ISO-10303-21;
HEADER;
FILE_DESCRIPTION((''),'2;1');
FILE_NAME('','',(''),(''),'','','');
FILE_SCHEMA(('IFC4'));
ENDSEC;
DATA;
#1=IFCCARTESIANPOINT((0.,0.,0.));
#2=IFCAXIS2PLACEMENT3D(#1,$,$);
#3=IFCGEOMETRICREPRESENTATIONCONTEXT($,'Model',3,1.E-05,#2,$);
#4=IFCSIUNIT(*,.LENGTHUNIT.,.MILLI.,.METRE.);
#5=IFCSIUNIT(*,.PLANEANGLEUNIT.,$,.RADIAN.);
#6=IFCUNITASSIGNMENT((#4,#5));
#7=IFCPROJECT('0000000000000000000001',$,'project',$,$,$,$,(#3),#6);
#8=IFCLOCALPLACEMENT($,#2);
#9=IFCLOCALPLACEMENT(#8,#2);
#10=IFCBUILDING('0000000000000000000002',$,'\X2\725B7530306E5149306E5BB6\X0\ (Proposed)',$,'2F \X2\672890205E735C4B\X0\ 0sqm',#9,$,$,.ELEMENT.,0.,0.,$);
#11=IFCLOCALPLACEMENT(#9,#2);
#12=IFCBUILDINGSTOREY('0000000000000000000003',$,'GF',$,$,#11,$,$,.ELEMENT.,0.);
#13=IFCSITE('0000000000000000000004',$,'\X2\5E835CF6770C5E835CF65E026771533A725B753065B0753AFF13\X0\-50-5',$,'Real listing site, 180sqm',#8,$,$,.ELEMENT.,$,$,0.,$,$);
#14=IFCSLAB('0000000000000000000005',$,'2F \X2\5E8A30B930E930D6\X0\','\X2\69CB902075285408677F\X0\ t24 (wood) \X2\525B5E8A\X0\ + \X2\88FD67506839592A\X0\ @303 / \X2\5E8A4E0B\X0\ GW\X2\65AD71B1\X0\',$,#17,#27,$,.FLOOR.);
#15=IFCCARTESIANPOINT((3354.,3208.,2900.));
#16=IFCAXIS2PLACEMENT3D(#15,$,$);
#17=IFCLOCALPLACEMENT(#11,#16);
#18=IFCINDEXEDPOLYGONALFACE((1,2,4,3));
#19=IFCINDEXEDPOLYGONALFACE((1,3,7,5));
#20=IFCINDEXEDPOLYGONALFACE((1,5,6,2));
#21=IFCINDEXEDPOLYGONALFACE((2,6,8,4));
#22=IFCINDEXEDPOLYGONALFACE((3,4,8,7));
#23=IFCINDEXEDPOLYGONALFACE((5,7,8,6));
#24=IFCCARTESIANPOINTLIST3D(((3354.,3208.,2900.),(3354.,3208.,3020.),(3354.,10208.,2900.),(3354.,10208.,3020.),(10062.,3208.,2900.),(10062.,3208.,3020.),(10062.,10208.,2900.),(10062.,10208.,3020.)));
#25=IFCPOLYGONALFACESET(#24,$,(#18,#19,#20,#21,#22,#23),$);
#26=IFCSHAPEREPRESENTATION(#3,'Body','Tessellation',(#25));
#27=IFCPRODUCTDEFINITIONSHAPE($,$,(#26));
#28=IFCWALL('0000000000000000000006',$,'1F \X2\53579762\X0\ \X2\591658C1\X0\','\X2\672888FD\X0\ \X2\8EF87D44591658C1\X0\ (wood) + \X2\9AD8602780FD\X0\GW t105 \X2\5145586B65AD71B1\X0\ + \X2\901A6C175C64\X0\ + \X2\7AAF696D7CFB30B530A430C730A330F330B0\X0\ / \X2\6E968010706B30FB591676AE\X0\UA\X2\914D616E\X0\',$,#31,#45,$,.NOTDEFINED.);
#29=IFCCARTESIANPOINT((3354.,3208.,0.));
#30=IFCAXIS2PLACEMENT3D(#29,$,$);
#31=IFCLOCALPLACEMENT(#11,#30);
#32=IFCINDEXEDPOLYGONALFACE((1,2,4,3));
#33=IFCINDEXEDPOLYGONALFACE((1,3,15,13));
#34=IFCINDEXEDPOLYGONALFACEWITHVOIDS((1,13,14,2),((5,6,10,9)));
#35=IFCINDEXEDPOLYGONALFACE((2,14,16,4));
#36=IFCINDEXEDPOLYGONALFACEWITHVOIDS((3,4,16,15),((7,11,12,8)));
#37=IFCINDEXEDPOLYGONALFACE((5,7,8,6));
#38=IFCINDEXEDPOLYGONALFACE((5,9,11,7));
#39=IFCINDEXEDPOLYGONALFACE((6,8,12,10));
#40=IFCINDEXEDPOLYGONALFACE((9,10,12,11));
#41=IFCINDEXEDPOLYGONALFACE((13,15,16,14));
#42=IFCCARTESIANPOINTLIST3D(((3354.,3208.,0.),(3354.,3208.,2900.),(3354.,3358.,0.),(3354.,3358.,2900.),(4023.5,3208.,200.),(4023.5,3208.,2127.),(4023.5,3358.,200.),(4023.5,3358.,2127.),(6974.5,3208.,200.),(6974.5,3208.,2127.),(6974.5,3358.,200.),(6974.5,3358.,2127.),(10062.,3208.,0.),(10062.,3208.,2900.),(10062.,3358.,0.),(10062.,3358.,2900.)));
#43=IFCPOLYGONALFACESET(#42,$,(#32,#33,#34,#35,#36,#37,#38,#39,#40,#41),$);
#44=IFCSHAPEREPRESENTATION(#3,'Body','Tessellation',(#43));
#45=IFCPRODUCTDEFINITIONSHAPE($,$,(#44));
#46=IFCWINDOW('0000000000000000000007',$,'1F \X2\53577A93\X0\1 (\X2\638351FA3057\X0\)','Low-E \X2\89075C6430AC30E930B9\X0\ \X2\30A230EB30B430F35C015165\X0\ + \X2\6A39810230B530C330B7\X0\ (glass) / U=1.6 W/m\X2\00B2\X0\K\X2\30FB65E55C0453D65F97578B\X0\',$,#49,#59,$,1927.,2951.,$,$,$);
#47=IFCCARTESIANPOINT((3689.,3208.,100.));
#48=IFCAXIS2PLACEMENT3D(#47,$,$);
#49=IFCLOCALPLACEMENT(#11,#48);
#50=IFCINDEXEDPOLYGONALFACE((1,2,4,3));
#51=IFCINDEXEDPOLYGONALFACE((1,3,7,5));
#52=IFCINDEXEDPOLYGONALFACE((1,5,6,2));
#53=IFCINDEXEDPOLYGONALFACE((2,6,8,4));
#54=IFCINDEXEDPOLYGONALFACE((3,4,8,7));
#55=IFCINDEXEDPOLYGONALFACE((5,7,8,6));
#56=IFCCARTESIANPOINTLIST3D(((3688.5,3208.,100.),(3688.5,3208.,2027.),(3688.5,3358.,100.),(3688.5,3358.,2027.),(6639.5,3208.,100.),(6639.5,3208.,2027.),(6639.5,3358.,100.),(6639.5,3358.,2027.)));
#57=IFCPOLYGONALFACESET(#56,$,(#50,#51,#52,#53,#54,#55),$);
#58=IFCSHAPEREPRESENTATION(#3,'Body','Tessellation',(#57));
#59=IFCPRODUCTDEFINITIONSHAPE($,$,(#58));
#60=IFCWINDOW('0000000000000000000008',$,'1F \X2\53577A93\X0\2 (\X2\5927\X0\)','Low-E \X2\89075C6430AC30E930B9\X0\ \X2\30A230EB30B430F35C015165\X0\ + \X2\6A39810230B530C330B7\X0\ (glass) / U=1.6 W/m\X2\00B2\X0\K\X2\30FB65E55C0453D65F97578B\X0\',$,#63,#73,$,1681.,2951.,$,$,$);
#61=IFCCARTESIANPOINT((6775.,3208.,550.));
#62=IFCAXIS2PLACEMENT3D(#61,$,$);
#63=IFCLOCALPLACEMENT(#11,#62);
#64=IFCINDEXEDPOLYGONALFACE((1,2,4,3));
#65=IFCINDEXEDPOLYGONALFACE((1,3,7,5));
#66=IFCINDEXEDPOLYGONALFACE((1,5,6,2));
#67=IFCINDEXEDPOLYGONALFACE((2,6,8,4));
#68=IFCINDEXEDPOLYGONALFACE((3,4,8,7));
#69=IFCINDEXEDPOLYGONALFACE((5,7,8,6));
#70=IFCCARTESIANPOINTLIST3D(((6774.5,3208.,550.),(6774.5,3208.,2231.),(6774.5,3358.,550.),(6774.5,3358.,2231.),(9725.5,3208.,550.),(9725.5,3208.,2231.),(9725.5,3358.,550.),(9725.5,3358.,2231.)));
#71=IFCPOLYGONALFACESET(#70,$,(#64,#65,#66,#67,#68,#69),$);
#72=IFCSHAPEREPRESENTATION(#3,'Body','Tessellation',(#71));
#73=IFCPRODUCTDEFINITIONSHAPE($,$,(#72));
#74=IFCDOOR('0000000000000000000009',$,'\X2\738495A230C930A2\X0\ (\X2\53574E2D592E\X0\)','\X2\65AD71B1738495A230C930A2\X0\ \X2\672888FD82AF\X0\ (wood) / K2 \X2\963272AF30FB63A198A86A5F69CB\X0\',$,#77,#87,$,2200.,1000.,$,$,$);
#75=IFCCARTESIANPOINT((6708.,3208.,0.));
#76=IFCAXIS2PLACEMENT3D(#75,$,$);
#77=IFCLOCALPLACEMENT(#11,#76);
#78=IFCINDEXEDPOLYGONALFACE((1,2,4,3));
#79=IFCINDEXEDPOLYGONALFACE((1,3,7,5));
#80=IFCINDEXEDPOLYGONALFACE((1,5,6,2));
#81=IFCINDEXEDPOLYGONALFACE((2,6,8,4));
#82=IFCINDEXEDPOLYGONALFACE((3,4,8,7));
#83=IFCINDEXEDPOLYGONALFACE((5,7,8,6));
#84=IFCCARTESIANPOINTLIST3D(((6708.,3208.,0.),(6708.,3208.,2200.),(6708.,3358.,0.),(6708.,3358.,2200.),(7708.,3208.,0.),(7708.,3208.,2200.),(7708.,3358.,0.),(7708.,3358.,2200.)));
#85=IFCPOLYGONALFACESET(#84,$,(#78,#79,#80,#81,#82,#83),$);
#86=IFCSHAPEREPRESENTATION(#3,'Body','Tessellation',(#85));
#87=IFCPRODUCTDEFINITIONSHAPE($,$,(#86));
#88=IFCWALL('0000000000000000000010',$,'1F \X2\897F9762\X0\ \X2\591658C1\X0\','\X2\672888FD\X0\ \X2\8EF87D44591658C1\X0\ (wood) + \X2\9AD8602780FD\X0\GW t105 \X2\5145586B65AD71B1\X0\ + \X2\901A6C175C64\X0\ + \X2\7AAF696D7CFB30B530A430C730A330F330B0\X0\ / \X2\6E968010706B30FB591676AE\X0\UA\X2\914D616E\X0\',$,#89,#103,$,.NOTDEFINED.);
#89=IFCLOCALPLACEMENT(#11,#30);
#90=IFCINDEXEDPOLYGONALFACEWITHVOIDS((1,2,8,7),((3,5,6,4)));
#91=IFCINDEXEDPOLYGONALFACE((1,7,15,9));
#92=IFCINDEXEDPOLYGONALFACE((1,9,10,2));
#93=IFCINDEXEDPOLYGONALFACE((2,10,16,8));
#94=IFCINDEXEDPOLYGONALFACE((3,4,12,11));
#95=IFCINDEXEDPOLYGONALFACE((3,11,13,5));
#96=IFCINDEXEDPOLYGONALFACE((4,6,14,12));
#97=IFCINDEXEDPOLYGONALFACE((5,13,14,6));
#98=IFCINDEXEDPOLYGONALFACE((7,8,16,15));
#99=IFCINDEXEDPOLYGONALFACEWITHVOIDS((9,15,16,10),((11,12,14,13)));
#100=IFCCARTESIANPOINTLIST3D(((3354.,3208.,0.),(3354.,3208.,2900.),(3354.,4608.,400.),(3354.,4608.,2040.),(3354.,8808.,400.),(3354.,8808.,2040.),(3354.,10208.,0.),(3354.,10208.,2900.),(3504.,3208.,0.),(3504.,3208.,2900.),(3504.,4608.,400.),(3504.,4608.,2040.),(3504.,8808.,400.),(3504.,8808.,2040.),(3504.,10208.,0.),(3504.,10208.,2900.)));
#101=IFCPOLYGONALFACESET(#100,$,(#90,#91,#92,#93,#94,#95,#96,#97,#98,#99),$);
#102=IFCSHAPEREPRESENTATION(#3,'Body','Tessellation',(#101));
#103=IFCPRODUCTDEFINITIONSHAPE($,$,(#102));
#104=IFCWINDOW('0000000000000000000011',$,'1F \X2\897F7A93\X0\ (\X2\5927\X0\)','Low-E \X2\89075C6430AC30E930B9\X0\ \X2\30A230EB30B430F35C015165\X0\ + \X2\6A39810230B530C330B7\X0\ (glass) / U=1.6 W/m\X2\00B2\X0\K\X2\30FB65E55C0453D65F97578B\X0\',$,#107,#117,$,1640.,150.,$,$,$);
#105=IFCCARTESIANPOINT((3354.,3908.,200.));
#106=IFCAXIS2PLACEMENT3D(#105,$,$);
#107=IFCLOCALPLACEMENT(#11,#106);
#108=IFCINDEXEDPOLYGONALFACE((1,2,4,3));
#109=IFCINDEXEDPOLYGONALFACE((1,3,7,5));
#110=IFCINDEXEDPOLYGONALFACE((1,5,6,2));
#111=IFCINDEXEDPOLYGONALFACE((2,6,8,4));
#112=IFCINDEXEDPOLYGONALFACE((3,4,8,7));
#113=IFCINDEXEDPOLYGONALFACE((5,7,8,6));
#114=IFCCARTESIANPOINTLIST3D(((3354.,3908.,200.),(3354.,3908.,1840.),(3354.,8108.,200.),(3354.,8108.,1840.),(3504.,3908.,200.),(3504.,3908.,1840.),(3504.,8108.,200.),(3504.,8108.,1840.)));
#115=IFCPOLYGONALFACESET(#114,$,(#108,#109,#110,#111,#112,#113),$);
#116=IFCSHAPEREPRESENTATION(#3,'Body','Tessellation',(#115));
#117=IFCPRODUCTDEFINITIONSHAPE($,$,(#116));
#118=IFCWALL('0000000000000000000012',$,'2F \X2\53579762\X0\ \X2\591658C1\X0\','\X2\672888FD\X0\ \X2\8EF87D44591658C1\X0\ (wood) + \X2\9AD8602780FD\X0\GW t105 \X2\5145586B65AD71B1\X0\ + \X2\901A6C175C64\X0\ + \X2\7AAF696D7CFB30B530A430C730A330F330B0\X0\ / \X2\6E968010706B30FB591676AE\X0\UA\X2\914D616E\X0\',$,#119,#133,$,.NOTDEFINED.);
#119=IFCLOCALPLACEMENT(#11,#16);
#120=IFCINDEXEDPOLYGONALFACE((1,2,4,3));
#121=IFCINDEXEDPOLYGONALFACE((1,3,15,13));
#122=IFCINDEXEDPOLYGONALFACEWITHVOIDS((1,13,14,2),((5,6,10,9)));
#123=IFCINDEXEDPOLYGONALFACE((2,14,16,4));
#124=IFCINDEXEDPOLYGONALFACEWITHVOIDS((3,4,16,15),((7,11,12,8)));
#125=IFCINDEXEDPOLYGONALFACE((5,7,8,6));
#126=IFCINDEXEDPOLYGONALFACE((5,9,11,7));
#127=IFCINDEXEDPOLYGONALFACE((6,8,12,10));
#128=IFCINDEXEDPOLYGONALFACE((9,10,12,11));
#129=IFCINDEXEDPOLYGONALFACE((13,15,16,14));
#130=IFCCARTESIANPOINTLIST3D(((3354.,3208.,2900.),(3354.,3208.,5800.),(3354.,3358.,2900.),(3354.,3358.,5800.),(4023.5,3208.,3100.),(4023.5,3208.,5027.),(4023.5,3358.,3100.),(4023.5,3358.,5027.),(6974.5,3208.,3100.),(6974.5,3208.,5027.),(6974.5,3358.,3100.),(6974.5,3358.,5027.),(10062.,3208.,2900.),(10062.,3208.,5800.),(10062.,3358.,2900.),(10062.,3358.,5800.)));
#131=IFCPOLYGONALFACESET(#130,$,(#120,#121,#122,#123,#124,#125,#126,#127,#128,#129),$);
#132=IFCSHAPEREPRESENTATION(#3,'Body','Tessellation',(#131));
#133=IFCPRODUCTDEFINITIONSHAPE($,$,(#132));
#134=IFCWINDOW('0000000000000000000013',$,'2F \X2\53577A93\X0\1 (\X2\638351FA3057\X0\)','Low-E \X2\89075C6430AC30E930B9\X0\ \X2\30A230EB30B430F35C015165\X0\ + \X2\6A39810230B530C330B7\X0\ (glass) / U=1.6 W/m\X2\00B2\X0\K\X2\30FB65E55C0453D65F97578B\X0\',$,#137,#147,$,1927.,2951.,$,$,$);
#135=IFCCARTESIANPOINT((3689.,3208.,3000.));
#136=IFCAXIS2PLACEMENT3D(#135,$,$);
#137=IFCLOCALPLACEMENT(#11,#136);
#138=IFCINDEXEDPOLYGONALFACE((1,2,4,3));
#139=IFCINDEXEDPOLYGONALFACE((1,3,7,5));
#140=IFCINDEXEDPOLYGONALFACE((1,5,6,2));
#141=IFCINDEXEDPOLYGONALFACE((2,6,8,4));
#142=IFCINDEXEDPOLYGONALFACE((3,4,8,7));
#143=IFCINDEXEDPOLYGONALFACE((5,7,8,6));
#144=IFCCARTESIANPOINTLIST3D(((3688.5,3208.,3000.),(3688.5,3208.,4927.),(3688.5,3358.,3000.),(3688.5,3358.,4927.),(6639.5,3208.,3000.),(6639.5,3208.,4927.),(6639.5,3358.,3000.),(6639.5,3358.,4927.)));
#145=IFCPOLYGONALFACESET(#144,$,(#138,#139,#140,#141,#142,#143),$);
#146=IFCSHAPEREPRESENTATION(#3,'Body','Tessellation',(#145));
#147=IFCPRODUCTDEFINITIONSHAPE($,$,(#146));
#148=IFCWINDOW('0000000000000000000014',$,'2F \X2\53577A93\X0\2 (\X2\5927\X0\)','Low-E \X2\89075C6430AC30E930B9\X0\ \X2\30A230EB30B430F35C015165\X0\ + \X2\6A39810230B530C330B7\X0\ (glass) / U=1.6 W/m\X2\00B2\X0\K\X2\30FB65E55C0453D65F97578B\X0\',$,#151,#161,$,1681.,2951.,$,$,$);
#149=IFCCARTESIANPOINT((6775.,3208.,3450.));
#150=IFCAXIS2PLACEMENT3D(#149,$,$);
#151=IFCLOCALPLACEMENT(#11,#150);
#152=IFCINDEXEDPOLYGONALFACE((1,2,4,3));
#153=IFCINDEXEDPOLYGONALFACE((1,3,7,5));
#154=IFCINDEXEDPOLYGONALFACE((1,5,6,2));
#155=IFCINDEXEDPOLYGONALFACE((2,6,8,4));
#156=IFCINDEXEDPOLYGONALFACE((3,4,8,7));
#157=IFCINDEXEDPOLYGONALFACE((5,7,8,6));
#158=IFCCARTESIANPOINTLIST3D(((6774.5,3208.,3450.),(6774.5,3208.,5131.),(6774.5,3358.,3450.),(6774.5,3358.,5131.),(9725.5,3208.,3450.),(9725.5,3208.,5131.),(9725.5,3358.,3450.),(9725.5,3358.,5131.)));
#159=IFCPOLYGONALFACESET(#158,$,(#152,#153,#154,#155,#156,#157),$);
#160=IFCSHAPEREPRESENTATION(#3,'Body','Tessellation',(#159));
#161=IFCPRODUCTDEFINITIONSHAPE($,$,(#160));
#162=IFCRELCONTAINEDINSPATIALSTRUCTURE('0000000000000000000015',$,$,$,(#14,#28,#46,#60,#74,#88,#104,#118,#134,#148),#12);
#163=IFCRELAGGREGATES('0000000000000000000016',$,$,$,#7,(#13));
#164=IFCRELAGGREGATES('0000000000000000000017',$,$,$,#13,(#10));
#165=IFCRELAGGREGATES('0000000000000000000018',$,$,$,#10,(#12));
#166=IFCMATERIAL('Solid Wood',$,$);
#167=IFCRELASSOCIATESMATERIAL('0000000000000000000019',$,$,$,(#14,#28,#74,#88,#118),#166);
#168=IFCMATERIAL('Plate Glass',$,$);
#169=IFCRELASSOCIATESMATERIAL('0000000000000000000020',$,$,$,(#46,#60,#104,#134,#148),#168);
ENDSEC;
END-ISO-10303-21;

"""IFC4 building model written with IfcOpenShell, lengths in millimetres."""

from ifc_helpers import new_model, si_unit, frame, frame_2d, origin, place, context, project, spatial, rectangle, extrude, material, element, fill, save


model = new_model("IFC4")

# Units and contexts
model_context = context("Model", 3, precision=1e-05, world=origin())
ifc_project = project(units=[si_unit("LENGTHUNIT", "METRE", prefix="MILLI"), si_unit("PLANEANGLEUNIT", "RADIAN")], contexts=[model_context])

# Site, building, storey
site_placement = place(None, origin())
site = spatial("IfcSite", under=ifc_project, at=site_placement, Name="広島県広島市東区牛田新町３-50-5", ObjectType="Real listing site, 180sqm", CompositionType="ELEMENT", RefElevation=0.0)
building_placement = place(site_placement, origin())
building = spatial("IfcBuilding", under=site, at=building_placement, Name="牛田の光の家 (Proposed)", ObjectType="2F 木造平屋 0sqm", CompositionType="ELEMENT", ElevationOfRefHeight=0.0, ElevationOfTerrain=0.0)
storey_placement = place(building_placement, origin())
storey = spatial("IfcBuildingStorey", under=building, at=storey_placement, Name="GF", CompositionType="ELEMENT", Elevation=0.0)

# Slab
ifc_material_1 = material(Name="Solid Wood")
slab_1_placement = place(storey_placement, frame((3354.0, 3208.0, 2900.0)))
element("IfcSlab", 1, at=slab_1_placement, inside=storey, material=ifc_material_1, Name="2F 床スラブ", Description="構造用合板 t24 (wood) 剛床 + 製材根太 @303 / 床下 GW断熱", PredefinedType="FLOOR", context=model_context, shape_type="SweptSolid", body=[
    extrude(rectangle(XDim=6708.0, YDim=7000.0, at=frame_2d((3354.0, 3500.0))), frame((3354.0, 3208.0, 2900.0)), (0.0, 0.0, 1.0), 120.0),
])

# Wall, openings, windows, door
wall_1_placement = place(storey_placement, frame((3354.0, 3208.0, 0.0)))
wall_1 = element("IfcWall", 2, at=wall_1_placement, inside=storey, material=ifc_material_1, Name="1F 南面 外壁", Description="木製 軸組外壁 (wood) + 高性能GW t105 充填断熱 + 通気層 + 窯業系サイディング / 準耐火・外皮UA配慮", PredefinedType="NOTDEFINED", context=model_context, shape_type="SweptSolid", body=[
    extrude(rectangle(XDim=6708.0, YDim=150.0, at=frame_2d((3354.0, 75.0))), frame((3354.0, 3208.0, 0.0)), (0.0, 0.0, 1.0), 2900.0),
])
opening_1_placement = place(storey_placement, frame((3689.0, 3208.0, 100.0)))
opening_1 = element("IfcOpeningElement", 3, at=opening_1_placement, cuts=wall_1, PredefinedType="NOTDEFINED", context=model_context, shape_type="SweptSolid", body=[
    extrude(rectangle(XDim=2951.0, YDim=150.0, at=frame_2d((1475.0, 75.0))), frame((3689.0, 3208.0, 100.0)), (0.0, 0.0, 1.0), 1927.0),
])
opening_2_placement = place(storey_placement, frame((6775.0, 3208.0, 550.0)))
opening_2 = element("IfcOpeningElement", 4, at=opening_2_placement, cuts=wall_1, PredefinedType="NOTDEFINED", context=model_context, shape_type="SweptSolid", body=[
    extrude(rectangle(XDim=2951.0, YDim=150.0, at=frame_2d((1475.0, 75.0))), frame((6775.0, 3208.0, 550.0)), (0.0, 0.0, 1.0), 1681.0),
])
opening_3_placement = place(storey_placement, frame((6708.0, 3208.0, 0.0)))
opening_3 = element("IfcOpeningElement", 5, at=opening_3_placement, cuts=wall_1, PredefinedType="NOTDEFINED", context=model_context, shape_type="SweptSolid", body=[
    extrude(rectangle(XDim=1000.0, YDim=150.0, at=frame_2d((500.0, 75.0))), frame((6708.0, 3208.0, 0.0)), (0.0, 0.0, 1.0), 2200.0),
])
ifc_material_2 = material(Name="Plate Glass")
window_1_placement = place(storey_placement, frame((3689.0, 3208.0, 100.0)))
window_1 = element("IfcWindow", 6, at=window_1_placement, inside=storey, material=ifc_material_2, Name="1F 南窓1 (掃出し)", Description="Low-E 複層ガラス アルゴン封入 + 樹脂サッシ (glass) / U=1.6 W/m²K・日射取得型", OverallHeight=1927.0, OverallWidth=2951.0, context=model_context, shape_type="SweptSolid", body=[
    extrude(rectangle(XDim=2951.0, YDim=150.0, at=frame_2d((1475.0, 75.0))), frame((3689.0, 3208.0, 100.0)), (0.0, 0.0, 1.0), 1927.0),
])
fill(opening_1, window_1)
window_2_placement = place(storey_placement, frame((6775.0, 3208.0, 550.0)))
window_2 = element("IfcWindow", 7, at=window_2_placement, inside=storey, material=ifc_material_2, Name="1F 南窓2 (大)", Description="Low-E 複層ガラス アルゴン封入 + 樹脂サッシ (glass) / U=1.6 W/m²K・日射取得型", OverallHeight=1681.0, OverallWidth=2951.0, context=model_context, shape_type="SweptSolid", body=[
    extrude(rectangle(XDim=2951.0, YDim=150.0, at=frame_2d((1475.0, 75.0))), frame((6775.0, 3208.0, 550.0)), (0.0, 0.0, 1.0), 1681.0),
])
fill(opening_2, window_2)
door_placement = place(storey_placement, frame((6708.0, 3208.0, 0.0)))
door = element("IfcDoor", 8, at=door_placement, inside=storey, material=ifc_material_1, Name="玄関ドア (南中央)", Description="断熱玄関ドア 木製芯 (wood) / K2 防犯・採風機構", OverallHeight=2200.0, OverallWidth=1000.0, context=model_context, shape_type="SweptSolid", body=[
    extrude(rectangle(XDim=1000.0, YDim=150.0, at=frame_2d((500.0, 75.0))), frame((6708.0, 3208.0, 0.0)), (0.0, 0.0, 1.0), 2200.0),
])
fill(opening_3, door)

# Wall, opening, window
wall_2_placement = place(storey_placement, frame((3354.0, 3208.0, 0.0)))
wall_2 = element("IfcWall", 9, at=wall_2_placement, inside=storey, material=ifc_material_1, Name="1F 西面 外壁", Description="木製 軸組外壁 (wood) + 高性能GW t105 充填断熱 + 通気層 + 窯業系サイディング / 準耐火・外皮UA配慮", PredefinedType="NOTDEFINED", context=model_context, shape_type="SweptSolid", body=[
    extrude(rectangle(XDim=150.0, YDim=7000.0, at=frame_2d((75.0, 3500.0))), frame((3354.0, 3208.0, 0.0)), (0.0, 0.0, 1.0), 2900.0),
])
opening_4_placement = place(storey_placement, frame((3354.0, 3908.0, 200.0)))
opening_4 = element("IfcOpeningElement", 10, at=opening_4_placement, cuts=wall_2, PredefinedType="NOTDEFINED", context=model_context, shape_type="SweptSolid", body=[
    extrude(rectangle(XDim=150.0, YDim=4200.0, at=frame_2d((75.0, 2100.0))), frame((3354.0, 3908.0, 200.0)), (0.0, 0.0, 1.0), 1640.0),
])
window_3_placement = place(storey_placement, frame((3354.0, 3908.0, 200.0)))
window_3 = element("IfcWindow", 11, at=window_3_placement, inside=storey, material=ifc_material_2, Name="1F 西窓 (大)", Description="Low-E 複層ガラス アルゴン封入 + 樹脂サッシ (glass) / U=1.6 W/m²K・日射取得型", OverallHeight=1640.0, OverallWidth=150.0, context=model_context, shape_type="SweptSolid", body=[
    extrude(rectangle(XDim=150.0, YDim=4200.0, at=frame_2d((75.0, 2100.0))), frame((3354.0, 3908.0, 200.0)), (0.0, 0.0, 1.0), 1640.0),
])
fill(opening_4, window_3)

# Wall, openings, windows
wall_3_placement = place(storey_placement, frame((3354.0, 3208.0, 2900.0)))
wall_3 = element("IfcWall", 12, at=wall_3_placement, inside=storey, material=ifc_material_1, Name="2F 南面 外壁", Description="木製 軸組外壁 (wood) + 高性能GW t105 充填断熱 + 通気層 + 窯業系サイディング / 準耐火・外皮UA配慮", PredefinedType="NOTDEFINED", context=model_context, shape_type="SweptSolid", body=[
    extrude(rectangle(XDim=6708.0, YDim=150.0, at=frame_2d((3354.0, 75.0))), frame((3354.0, 3208.0, 2900.0)), (0.0, 0.0, 1.0), 2900.0),
])
opening_5_placement = place(storey_placement, frame((3689.0, 3208.0, 3000.0)))
opening_5 = element("IfcOpeningElement", 13, at=opening_5_placement, cuts=wall_3, PredefinedType="NOTDEFINED", context=model_context, shape_type="SweptSolid", body=[
    extrude(rectangle(XDim=2951.0, YDim=150.0, at=frame_2d((1475.0, 75.0))), frame((3689.0, 3208.0, 3000.0)), (0.0, 0.0, 1.0), 1927.0),
])
opening_6_placement = place(storey_placement, frame((6775.0, 3208.0, 3450.0)))
opening_6 = element("IfcOpeningElement", 14, at=opening_6_placement, cuts=wall_3, PredefinedType="NOTDEFINED", context=model_context, shape_type="SweptSolid", body=[
    extrude(rectangle(XDim=2951.0, YDim=150.0, at=frame_2d((1475.0, 75.0))), frame((6775.0, 3208.0, 3450.0)), (0.0, 0.0, 1.0), 1681.0),
])
window_4_placement = place(storey_placement, frame((3689.0, 3208.0, 3000.0)))
window_4 = element("IfcWindow", 15, at=window_4_placement, inside=storey, material=ifc_material_2, Name="2F 南窓1 (掃出し)", Description="Low-E 複層ガラス アルゴン封入 + 樹脂サッシ (glass) / U=1.6 W/m²K・日射取得型", OverallHeight=1927.0, OverallWidth=2951.0, context=model_context, shape_type="SweptSolid", body=[
    extrude(rectangle(XDim=2951.0, YDim=150.0, at=frame_2d((1475.0, 75.0))), frame((3689.0, 3208.0, 3000.0)), (0.0, 0.0, 1.0), 1927.0),
])
fill(opening_5, window_4)
window_5_placement = place(storey_placement, frame((6775.0, 3208.0, 3450.0)))
window_5 = element("IfcWindow", 16, at=window_5_placement, inside=storey, material=ifc_material_2, Name="2F 南窓2 (大)", Description="Low-E 複層ガラス アルゴン封入 + 樹脂サッシ (glass) / U=1.6 W/m²K・日射取得型", OverallHeight=1681.0, OverallWidth=2951.0, context=model_context, shape_type="SweptSolid", body=[
    extrude(rectangle(XDim=2951.0, YDim=150.0, at=frame_2d((1475.0, 75.0))), frame((6775.0, 3208.0, 3450.0)), (0.0, 0.0, 1.0), 1681.0),
])
fill(opening_6, window_5)

save(model, "model.ifc")
